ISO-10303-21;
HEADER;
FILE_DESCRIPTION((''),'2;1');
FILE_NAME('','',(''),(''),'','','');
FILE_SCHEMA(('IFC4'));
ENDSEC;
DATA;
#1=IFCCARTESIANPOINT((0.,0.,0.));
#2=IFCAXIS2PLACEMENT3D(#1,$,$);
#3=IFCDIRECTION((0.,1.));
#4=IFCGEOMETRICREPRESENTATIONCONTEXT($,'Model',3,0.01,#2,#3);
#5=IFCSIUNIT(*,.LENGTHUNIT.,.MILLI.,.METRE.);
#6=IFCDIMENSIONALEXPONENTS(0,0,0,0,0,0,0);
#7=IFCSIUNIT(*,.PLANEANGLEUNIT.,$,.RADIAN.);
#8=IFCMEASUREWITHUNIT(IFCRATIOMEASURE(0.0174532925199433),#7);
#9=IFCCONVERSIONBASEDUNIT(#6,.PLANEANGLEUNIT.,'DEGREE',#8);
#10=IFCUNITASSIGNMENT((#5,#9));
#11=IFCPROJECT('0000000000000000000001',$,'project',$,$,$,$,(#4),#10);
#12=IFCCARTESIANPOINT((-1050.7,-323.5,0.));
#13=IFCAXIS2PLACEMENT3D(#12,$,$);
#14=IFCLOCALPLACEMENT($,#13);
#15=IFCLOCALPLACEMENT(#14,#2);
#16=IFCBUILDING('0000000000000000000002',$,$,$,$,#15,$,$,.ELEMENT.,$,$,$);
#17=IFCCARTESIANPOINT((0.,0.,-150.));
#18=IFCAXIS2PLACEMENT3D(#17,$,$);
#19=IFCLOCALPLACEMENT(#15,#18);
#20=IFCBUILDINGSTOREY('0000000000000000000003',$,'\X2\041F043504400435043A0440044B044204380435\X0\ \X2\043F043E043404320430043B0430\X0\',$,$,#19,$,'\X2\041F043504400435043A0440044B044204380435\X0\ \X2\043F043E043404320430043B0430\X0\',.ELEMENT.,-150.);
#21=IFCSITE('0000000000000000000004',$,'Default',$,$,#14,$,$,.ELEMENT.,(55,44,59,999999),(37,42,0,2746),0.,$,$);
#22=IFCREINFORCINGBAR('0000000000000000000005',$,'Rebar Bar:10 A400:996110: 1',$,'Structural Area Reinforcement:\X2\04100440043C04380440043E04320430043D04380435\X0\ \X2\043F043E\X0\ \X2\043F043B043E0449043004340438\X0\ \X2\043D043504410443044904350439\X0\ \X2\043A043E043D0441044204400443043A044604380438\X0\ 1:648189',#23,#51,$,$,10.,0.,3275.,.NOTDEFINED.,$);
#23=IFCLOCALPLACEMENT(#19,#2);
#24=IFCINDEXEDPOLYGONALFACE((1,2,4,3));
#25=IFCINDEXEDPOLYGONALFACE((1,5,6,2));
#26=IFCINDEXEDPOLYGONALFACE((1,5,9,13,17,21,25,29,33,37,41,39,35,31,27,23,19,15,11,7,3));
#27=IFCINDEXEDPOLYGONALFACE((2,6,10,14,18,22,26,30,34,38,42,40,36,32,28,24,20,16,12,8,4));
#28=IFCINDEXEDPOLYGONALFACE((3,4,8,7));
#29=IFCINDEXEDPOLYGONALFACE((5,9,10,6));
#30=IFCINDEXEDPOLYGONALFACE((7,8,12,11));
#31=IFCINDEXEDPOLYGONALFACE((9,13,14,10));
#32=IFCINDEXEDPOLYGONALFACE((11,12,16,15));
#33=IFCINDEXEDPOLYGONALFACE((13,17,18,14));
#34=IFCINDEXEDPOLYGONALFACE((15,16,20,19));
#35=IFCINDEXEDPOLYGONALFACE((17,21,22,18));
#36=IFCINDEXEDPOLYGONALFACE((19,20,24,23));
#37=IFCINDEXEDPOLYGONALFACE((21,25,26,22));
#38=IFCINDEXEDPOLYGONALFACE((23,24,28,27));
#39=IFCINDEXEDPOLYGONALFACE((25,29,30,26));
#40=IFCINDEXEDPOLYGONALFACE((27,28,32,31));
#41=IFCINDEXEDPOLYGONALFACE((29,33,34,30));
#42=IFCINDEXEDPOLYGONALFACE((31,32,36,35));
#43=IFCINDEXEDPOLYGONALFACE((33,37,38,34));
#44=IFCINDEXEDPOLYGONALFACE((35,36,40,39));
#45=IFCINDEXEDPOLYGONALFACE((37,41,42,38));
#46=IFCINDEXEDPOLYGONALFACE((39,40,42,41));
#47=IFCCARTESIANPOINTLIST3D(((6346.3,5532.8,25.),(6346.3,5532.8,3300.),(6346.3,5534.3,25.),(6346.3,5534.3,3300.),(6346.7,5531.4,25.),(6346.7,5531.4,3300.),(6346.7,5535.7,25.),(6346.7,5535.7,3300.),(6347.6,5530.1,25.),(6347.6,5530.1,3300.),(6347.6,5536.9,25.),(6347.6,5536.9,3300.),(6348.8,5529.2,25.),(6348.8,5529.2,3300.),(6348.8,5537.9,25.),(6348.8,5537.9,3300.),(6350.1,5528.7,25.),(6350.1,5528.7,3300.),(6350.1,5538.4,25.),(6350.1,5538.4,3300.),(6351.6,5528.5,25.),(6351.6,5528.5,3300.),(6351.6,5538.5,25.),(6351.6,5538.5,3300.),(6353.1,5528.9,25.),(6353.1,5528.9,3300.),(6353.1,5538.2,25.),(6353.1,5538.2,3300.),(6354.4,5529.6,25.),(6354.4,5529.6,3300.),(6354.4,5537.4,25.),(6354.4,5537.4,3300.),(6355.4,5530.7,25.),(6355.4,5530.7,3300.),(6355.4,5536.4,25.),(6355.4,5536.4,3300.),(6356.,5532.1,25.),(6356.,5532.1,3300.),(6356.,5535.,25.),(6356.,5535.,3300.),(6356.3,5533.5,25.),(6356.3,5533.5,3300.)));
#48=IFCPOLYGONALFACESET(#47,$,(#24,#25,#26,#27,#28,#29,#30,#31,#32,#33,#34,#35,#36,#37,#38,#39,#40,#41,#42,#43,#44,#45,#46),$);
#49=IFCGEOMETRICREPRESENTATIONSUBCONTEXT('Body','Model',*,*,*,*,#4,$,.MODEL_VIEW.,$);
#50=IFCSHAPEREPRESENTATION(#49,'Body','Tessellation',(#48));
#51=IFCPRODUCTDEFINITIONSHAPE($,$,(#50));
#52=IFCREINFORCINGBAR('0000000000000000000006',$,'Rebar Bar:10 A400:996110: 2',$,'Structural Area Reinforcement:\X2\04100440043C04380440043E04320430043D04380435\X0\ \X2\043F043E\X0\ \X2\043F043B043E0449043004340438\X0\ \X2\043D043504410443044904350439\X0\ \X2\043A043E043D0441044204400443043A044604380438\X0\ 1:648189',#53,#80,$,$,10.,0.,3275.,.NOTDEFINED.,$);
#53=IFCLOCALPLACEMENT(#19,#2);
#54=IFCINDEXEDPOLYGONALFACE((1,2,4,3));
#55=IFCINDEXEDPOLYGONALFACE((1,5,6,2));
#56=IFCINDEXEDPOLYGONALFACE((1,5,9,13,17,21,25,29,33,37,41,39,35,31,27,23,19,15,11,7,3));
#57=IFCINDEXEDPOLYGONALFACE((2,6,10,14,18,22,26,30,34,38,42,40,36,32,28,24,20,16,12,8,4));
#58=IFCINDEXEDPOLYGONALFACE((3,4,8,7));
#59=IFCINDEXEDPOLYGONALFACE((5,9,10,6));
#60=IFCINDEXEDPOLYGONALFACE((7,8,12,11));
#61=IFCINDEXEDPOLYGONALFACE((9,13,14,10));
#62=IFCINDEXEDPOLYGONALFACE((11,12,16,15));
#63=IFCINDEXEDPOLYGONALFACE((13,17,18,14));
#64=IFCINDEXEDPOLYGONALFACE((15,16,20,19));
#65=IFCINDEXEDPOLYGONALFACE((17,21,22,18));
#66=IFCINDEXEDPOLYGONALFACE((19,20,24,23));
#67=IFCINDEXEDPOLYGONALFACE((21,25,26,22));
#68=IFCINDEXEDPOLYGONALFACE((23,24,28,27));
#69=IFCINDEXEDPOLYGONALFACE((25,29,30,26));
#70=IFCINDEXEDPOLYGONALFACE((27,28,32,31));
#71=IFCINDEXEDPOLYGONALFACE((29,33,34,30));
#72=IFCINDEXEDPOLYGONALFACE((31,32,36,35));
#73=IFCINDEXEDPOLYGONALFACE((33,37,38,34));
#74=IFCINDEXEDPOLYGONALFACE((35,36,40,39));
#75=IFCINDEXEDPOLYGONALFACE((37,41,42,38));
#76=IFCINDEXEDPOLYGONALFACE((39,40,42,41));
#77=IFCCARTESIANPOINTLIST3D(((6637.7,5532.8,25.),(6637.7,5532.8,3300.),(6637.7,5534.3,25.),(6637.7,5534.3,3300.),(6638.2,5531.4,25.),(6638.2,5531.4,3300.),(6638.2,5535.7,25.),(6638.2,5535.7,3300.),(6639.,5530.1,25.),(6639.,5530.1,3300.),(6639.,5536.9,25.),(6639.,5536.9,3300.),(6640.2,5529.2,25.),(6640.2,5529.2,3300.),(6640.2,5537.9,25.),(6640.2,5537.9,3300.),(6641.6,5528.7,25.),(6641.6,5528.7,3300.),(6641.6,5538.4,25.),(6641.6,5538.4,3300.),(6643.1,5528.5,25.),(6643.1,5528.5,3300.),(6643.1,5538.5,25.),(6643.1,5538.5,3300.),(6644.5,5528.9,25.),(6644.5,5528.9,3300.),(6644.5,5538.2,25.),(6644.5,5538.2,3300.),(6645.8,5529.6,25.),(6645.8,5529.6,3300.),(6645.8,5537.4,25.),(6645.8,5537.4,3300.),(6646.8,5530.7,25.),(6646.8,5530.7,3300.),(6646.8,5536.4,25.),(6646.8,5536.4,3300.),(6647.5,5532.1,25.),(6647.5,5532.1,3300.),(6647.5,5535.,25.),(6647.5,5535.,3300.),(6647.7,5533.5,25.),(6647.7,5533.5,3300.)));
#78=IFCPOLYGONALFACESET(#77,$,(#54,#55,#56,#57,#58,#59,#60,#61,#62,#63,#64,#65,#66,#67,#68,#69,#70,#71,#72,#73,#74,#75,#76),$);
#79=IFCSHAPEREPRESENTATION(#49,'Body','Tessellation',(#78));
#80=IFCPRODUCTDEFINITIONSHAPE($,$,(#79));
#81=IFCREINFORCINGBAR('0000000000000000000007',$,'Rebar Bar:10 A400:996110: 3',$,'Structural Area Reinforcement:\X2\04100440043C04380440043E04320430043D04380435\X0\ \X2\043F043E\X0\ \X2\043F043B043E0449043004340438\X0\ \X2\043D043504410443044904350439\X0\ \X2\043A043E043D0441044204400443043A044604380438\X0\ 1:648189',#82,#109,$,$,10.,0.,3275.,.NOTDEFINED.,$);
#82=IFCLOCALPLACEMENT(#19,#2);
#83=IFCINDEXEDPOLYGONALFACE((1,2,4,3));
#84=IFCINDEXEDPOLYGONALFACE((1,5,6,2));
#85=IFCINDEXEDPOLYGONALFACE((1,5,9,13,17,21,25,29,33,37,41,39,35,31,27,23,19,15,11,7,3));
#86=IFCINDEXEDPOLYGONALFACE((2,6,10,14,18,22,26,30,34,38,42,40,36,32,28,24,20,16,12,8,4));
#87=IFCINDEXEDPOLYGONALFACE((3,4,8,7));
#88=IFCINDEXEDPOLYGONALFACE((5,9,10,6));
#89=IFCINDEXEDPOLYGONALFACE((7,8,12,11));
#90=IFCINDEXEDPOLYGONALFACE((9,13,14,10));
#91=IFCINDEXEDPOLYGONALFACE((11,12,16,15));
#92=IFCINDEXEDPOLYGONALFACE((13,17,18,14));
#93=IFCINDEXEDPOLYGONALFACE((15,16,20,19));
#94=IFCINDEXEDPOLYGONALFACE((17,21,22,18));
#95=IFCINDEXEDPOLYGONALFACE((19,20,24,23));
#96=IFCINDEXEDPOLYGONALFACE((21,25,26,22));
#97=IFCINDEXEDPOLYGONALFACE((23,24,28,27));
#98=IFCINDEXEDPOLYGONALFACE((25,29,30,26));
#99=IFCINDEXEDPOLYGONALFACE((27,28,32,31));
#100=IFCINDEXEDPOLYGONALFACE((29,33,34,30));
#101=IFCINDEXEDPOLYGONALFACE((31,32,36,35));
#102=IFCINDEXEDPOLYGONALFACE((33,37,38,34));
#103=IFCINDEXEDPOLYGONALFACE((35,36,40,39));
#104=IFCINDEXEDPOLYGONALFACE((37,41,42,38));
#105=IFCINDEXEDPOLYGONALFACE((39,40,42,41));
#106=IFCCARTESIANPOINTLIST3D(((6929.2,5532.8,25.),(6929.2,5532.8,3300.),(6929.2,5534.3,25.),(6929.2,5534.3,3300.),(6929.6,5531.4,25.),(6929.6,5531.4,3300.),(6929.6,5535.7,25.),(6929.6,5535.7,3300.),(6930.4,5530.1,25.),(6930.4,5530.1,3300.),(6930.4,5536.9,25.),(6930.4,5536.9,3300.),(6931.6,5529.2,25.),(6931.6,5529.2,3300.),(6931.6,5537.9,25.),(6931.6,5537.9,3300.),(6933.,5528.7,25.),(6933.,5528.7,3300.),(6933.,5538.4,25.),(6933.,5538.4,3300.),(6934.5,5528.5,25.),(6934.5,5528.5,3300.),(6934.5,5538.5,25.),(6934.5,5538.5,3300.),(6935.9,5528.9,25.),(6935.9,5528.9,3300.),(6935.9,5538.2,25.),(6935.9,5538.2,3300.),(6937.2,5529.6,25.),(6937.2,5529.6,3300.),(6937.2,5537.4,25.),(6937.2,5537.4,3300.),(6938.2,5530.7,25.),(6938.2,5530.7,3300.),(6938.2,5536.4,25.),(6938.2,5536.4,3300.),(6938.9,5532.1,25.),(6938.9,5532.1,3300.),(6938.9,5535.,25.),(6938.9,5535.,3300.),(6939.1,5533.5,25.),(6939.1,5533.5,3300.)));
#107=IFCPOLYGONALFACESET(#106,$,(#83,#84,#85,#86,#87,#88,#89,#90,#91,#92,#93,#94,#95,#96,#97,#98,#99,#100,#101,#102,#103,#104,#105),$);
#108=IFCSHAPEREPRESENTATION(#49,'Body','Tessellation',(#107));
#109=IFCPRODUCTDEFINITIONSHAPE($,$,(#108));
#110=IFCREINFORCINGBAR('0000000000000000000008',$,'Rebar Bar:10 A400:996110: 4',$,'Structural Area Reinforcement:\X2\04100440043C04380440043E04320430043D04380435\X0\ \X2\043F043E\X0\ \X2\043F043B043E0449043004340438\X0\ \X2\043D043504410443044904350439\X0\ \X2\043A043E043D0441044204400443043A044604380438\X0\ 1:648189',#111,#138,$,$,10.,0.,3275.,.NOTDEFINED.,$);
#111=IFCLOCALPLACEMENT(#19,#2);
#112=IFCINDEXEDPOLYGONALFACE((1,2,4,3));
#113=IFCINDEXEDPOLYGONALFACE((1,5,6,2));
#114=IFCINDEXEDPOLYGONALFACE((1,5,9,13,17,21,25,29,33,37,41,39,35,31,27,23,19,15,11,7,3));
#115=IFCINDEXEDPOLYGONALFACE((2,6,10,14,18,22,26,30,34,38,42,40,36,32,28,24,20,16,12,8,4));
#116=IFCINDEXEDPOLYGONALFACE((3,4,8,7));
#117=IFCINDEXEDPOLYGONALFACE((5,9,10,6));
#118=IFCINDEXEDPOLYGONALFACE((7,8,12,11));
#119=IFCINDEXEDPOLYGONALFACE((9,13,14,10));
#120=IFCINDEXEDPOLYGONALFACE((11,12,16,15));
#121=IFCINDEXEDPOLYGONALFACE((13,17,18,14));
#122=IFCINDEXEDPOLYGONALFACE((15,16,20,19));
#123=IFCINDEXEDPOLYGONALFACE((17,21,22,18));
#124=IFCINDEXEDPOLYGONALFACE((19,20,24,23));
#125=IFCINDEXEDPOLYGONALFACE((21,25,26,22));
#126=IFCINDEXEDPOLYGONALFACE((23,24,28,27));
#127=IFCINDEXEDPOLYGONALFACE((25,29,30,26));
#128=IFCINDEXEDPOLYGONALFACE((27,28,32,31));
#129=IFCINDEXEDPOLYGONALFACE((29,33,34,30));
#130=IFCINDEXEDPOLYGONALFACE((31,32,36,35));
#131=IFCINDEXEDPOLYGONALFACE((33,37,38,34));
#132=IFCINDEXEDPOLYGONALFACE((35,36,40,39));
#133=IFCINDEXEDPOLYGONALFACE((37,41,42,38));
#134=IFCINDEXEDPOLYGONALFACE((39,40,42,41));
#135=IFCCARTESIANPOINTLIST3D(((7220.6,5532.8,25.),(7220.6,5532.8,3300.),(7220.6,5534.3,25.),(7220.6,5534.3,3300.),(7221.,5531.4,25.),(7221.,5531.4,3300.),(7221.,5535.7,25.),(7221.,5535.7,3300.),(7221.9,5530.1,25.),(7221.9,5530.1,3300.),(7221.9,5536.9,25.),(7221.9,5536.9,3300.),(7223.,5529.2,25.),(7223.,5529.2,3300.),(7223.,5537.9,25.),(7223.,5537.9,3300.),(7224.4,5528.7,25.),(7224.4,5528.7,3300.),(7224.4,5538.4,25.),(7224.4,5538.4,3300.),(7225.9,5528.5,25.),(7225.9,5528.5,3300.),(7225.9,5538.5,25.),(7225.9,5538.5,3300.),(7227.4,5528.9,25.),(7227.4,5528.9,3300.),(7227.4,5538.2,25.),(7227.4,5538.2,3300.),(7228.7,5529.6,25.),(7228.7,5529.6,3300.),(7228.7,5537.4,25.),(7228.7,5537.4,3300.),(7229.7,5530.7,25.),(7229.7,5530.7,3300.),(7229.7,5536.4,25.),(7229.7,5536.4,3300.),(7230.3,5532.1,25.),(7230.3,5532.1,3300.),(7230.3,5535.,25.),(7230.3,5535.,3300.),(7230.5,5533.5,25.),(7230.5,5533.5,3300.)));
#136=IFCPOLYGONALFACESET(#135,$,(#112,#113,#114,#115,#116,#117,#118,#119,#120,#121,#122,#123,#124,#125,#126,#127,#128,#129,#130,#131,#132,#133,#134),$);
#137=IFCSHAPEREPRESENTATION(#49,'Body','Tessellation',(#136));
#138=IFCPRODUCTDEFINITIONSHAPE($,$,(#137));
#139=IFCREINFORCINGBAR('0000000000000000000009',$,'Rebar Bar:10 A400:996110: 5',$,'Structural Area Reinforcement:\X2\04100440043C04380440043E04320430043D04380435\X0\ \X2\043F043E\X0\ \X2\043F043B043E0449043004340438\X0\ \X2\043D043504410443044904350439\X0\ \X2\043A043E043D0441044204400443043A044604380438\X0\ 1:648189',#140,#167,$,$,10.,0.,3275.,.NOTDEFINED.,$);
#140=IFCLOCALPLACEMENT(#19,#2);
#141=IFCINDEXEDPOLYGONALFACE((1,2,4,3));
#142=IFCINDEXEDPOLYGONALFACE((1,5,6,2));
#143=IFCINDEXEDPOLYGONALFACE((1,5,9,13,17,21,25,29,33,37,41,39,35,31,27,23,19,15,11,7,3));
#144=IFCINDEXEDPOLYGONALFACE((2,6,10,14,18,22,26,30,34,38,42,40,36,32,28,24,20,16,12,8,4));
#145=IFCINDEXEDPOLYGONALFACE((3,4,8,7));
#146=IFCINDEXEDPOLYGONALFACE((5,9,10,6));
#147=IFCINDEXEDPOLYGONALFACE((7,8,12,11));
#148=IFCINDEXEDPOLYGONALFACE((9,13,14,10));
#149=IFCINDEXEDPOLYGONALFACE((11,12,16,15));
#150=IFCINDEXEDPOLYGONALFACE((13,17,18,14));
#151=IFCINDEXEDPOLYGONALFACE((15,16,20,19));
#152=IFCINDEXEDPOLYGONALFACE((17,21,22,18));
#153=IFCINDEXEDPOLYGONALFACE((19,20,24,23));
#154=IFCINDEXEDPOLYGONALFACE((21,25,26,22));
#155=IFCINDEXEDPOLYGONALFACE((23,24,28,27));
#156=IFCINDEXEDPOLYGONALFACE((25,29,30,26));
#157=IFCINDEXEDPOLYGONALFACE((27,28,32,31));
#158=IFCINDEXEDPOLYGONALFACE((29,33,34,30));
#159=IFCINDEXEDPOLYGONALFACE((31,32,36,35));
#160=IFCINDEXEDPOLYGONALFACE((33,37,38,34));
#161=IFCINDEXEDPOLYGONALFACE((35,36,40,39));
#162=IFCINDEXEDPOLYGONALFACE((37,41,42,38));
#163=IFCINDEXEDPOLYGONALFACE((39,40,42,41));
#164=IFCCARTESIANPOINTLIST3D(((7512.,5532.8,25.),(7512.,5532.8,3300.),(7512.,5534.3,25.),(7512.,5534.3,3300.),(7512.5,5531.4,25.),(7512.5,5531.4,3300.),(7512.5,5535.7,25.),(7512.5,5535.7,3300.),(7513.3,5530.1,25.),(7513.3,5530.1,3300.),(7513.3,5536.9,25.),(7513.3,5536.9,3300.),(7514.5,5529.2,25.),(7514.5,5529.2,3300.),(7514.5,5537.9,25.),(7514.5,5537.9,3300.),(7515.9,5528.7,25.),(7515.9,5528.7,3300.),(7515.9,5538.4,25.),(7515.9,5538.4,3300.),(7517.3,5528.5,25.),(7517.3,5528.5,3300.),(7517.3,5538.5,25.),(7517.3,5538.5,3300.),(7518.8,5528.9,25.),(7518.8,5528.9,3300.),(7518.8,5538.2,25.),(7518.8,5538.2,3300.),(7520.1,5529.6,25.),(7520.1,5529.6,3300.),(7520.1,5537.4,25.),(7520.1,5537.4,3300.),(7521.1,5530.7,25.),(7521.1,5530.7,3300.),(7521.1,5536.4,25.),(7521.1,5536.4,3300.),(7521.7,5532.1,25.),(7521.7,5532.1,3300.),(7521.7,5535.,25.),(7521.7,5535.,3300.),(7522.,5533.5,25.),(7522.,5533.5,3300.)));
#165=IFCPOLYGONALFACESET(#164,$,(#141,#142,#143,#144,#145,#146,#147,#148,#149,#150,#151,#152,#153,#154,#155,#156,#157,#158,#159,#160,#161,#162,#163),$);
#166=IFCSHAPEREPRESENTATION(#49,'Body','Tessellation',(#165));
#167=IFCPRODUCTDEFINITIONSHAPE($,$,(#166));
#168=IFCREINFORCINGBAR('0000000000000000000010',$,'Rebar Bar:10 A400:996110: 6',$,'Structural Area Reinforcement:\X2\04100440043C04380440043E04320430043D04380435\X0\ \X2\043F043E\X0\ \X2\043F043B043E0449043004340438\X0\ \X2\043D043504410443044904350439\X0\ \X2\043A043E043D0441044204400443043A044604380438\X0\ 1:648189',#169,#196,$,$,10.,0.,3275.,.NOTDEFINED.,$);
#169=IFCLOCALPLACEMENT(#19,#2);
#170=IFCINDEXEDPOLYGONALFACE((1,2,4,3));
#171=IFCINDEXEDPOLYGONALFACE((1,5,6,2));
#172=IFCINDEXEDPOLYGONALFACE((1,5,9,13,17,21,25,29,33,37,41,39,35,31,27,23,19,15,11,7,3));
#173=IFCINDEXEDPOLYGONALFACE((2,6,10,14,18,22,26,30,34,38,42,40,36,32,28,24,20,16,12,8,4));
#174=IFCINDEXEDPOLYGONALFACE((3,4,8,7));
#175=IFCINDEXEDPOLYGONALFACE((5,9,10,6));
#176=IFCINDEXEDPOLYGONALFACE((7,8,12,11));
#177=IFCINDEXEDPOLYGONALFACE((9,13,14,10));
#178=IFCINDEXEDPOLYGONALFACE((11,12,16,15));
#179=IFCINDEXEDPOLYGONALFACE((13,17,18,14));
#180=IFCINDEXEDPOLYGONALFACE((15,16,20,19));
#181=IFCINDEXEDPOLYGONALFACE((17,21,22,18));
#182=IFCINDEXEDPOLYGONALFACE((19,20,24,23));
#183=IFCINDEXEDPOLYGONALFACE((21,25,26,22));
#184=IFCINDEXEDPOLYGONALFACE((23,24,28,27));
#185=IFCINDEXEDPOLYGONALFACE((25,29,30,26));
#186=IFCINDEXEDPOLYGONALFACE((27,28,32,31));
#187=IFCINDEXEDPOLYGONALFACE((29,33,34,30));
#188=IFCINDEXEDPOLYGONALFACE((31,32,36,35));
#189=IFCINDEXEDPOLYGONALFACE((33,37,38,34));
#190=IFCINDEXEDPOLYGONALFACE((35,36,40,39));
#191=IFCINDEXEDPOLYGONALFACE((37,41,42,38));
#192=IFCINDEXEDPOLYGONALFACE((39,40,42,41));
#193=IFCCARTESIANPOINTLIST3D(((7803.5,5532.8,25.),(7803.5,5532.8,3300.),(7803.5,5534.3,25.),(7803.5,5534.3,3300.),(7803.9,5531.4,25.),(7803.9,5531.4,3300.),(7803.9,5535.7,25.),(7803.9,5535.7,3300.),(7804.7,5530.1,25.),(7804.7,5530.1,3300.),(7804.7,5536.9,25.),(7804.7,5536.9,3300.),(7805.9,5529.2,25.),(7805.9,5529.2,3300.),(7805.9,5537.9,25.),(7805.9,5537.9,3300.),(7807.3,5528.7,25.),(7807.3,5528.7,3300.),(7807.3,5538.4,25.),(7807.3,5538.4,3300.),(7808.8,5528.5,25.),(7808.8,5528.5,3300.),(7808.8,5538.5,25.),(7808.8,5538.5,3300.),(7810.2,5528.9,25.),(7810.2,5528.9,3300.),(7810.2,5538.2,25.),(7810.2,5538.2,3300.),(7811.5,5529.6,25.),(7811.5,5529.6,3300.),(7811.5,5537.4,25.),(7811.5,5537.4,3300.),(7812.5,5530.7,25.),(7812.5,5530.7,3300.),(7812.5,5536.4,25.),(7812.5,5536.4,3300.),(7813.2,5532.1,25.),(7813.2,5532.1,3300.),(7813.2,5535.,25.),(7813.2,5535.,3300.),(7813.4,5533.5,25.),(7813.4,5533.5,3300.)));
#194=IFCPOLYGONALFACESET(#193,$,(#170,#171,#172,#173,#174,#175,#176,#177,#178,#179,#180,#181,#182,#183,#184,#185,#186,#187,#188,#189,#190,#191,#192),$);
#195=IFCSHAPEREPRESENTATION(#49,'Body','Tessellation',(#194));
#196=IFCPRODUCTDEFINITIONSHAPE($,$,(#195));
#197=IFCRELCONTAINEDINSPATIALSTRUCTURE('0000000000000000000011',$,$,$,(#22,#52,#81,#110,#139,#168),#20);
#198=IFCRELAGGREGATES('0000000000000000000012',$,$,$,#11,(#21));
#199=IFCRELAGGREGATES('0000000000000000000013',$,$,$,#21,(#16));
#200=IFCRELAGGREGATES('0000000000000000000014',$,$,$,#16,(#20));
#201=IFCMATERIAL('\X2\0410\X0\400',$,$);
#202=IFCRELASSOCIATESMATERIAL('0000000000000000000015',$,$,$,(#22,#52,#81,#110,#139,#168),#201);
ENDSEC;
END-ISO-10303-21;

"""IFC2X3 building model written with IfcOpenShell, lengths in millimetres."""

from ifc_helpers import new_model, entity, si_unit, converted_unit, direction, frame, origin, place, context, subcontext, project, spatial, material, element, save


model = new_model("IFC2X3")

# Units and contexts
model_context = context("Model", 3, precision=0.01, world=origin(), true_north=direction((0.0, 1.0)))
body_context = subcontext(model_context, "Body", "Model", "MODEL_VIEW")
ifc_project = project(units=[si_unit("LENGTHUNIT", "METRE", prefix="MILLI"), converted_unit("PLANEANGLEUNIT", "DEGREE", entity("IfcRatioMeasure", 0.0174532925199433), si_unit("PLANEANGLEUNIT", "RADIAN"), dimensions=[0, 0, 0, 0, 0, 0, 0])], contexts=[model_context])

# Site, building, storey
site_placement = place(None, frame((-1050.7, -323.5, 0.0)))
site = spatial("IfcSite", under=ifc_project, at=site_placement, Name="Default", CompositionType="ELEMENT", RefLatitude=(55, 44, 59, 999999), RefLongitude=(37, 42, 0, 2746), RefElevation=0.0)
building_placement = place(site_placement, origin())
building = spatial("IfcBuilding", under=site, at=building_placement, CompositionType="ELEMENT")
storey_placement = place(building_placement, frame((0.0, 0.0, -150.0)))
storey = spatial("IfcBuildingStorey", under=building, at=storey_placement, Name="Перекрытие подвала", LongName="Перекрытие подвала", CompositionType="ELEMENT", Elevation=-150.0)

# Reinforcing bars
ifc_material = material(Name="А400")
reinforcing_bar_1_placement = place(storey_placement, origin())
element("IfcReinforcingBar", 1, at=reinforcing_bar_1_placement, inside=storey, material=ifc_material, Name="Rebar Bar:10 A400:996110: 1", ObjectType="Structural Area Reinforcement:Армирование по площади несущей конструкции 1:648189", BarLength=3275.0, BarRole="NOTDEFINED", CrossSectionArea=0.0, NominalDiameter=10.0, context=body_context, shape_type="AdvancedSweptSolid", body=[
    entity("IfcSweptDiskSolid", entity("IfcCompositeCurve", [entity("IfcCompositeCurveSegment", "CONTINUOUS", True, entity("IfcPolyline", [entity("IfcCartesianPoint", [6351.3, 5533.5, 25.0]), entity("IfcCartesianPoint", [6351.3, 5533.5, 3300.0])]))], False), 5.0, None, 0.0, 1.0),
])
reinforcing_bar_2_placement = place(storey_placement, origin())
element("IfcReinforcingBar", 2, at=reinforcing_bar_2_placement, inside=storey, material=ifc_material, Name="Rebar Bar:10 A400:996110: 2", ObjectType="Structural Area Reinforcement:Армирование по площади несущей конструкции 1:648189", BarLength=3275.0, BarRole="NOTDEFINED", CrossSectionArea=0.0, NominalDiameter=10.0, context=body_context, shape_type="AdvancedSweptSolid", body=[
    entity("IfcSweptDiskSolid", entity("IfcCompositeCurve", [entity("IfcCompositeCurveSegment", "CONTINUOUS", True, entity("IfcPolyline", [entity("IfcCartesianPoint", [6642.7, 5533.5, 25.0]), entity("IfcCartesianPoint", [6642.7, 5533.5, 3300.0])]))], False), 5.0, None, 0.0, 1.0),
])
reinforcing_bar_3_placement = place(storey_placement, origin())
element("IfcReinforcingBar", 3, at=reinforcing_bar_3_placement, inside=storey, material=ifc_material, Name="Rebar Bar:10 A400:996110: 3", ObjectType="Structural Area Reinforcement:Армирование по площади несущей конструкции 1:648189", BarLength=3275.0, BarRole="NOTDEFINED", CrossSectionArea=0.0, NominalDiameter=10.0, context=body_context, shape_type="AdvancedSweptSolid", body=[
    entity("IfcSweptDiskSolid", entity("IfcCompositeCurve", [entity("IfcCompositeCurveSegment", "CONTINUOUS", True, entity("IfcPolyline", [entity("IfcCartesianPoint", [6934.1, 5533.5, 25.0]), entity("IfcCartesianPoint", [6934.1, 5533.5, 3300.0])]))], False), 5.0, None, 0.0, 1.0),
])
reinforcing_bar_4_placement = place(storey_placement, origin())
element("IfcReinforcingBar", 4, at=reinforcing_bar_4_placement, inside=storey, material=ifc_material, Name="Rebar Bar:10 A400:996110: 4", ObjectType="Structural Area Reinforcement:Армирование по площади несущей конструкции 1:648189", BarLength=3275.0, BarRole="NOTDEFINED", CrossSectionArea=0.0, NominalDiameter=10.0, context=body_context, shape_type="AdvancedSweptSolid", body=[
    entity("IfcSweptDiskSolid", entity("IfcCompositeCurve", [entity("IfcCompositeCurveSegment", "CONTINUOUS", True, entity("IfcPolyline", [entity("IfcCartesianPoint", [7225.5, 5533.5, 25.0]), entity("IfcCartesianPoint", [7225.5, 5533.5, 3300.0])]))], False), 5.0, None, 0.0, 1.0),
])
reinforcing_bar_5_placement = place(storey_placement, origin())
element("IfcReinforcingBar", 5, at=reinforcing_bar_5_placement, inside=storey, material=ifc_material, Name="Rebar Bar:10 A400:996110: 5", ObjectType="Structural Area Reinforcement:Армирование по площади несущей конструкции 1:648189", BarLength=3275.0, BarRole="NOTDEFINED", CrossSectionArea=0.0, NominalDiameter=10.0, context=body_context, shape_type="AdvancedSweptSolid", body=[
    entity("IfcSweptDiskSolid", entity("IfcCompositeCurve", [entity("IfcCompositeCurveSegment", "CONTINUOUS", True, entity("IfcPolyline", [entity("IfcCartesianPoint", [7517.0, 5533.5, 25.0]), entity("IfcCartesianPoint", [7517.0, 5533.5, 3300.0])]))], False), 5.0, None, 0.0, 1.0),
])
reinforcing_bar_6_placement = place(storey_placement, origin())
element("IfcReinforcingBar", 6, at=reinforcing_bar_6_placement, inside=storey, material=ifc_material, Name="Rebar Bar:10 A400:996110: 6", ObjectType="Structural Area Reinforcement:Армирование по площади несущей конструкции 1:648189", BarLength=3275.0, BarRole="NOTDEFINED", CrossSectionArea=0.0, NominalDiameter=10.0, context=body_context, shape_type="AdvancedSweptSolid", body=[
    entity("IfcSweptDiskSolid", entity("IfcCompositeCurve", [entity("IfcCompositeCurveSegment", "CONTINUOUS", True, entity("IfcPolyline", [entity("IfcCartesianPoint", [7808.4, 5533.5, 25.0]), entity("IfcCartesianPoint", [7808.4, 5533.5, 3300.0])]))], False), 5.0, None, 0.0, 1.0),
])

save(model, "model.ifc")
